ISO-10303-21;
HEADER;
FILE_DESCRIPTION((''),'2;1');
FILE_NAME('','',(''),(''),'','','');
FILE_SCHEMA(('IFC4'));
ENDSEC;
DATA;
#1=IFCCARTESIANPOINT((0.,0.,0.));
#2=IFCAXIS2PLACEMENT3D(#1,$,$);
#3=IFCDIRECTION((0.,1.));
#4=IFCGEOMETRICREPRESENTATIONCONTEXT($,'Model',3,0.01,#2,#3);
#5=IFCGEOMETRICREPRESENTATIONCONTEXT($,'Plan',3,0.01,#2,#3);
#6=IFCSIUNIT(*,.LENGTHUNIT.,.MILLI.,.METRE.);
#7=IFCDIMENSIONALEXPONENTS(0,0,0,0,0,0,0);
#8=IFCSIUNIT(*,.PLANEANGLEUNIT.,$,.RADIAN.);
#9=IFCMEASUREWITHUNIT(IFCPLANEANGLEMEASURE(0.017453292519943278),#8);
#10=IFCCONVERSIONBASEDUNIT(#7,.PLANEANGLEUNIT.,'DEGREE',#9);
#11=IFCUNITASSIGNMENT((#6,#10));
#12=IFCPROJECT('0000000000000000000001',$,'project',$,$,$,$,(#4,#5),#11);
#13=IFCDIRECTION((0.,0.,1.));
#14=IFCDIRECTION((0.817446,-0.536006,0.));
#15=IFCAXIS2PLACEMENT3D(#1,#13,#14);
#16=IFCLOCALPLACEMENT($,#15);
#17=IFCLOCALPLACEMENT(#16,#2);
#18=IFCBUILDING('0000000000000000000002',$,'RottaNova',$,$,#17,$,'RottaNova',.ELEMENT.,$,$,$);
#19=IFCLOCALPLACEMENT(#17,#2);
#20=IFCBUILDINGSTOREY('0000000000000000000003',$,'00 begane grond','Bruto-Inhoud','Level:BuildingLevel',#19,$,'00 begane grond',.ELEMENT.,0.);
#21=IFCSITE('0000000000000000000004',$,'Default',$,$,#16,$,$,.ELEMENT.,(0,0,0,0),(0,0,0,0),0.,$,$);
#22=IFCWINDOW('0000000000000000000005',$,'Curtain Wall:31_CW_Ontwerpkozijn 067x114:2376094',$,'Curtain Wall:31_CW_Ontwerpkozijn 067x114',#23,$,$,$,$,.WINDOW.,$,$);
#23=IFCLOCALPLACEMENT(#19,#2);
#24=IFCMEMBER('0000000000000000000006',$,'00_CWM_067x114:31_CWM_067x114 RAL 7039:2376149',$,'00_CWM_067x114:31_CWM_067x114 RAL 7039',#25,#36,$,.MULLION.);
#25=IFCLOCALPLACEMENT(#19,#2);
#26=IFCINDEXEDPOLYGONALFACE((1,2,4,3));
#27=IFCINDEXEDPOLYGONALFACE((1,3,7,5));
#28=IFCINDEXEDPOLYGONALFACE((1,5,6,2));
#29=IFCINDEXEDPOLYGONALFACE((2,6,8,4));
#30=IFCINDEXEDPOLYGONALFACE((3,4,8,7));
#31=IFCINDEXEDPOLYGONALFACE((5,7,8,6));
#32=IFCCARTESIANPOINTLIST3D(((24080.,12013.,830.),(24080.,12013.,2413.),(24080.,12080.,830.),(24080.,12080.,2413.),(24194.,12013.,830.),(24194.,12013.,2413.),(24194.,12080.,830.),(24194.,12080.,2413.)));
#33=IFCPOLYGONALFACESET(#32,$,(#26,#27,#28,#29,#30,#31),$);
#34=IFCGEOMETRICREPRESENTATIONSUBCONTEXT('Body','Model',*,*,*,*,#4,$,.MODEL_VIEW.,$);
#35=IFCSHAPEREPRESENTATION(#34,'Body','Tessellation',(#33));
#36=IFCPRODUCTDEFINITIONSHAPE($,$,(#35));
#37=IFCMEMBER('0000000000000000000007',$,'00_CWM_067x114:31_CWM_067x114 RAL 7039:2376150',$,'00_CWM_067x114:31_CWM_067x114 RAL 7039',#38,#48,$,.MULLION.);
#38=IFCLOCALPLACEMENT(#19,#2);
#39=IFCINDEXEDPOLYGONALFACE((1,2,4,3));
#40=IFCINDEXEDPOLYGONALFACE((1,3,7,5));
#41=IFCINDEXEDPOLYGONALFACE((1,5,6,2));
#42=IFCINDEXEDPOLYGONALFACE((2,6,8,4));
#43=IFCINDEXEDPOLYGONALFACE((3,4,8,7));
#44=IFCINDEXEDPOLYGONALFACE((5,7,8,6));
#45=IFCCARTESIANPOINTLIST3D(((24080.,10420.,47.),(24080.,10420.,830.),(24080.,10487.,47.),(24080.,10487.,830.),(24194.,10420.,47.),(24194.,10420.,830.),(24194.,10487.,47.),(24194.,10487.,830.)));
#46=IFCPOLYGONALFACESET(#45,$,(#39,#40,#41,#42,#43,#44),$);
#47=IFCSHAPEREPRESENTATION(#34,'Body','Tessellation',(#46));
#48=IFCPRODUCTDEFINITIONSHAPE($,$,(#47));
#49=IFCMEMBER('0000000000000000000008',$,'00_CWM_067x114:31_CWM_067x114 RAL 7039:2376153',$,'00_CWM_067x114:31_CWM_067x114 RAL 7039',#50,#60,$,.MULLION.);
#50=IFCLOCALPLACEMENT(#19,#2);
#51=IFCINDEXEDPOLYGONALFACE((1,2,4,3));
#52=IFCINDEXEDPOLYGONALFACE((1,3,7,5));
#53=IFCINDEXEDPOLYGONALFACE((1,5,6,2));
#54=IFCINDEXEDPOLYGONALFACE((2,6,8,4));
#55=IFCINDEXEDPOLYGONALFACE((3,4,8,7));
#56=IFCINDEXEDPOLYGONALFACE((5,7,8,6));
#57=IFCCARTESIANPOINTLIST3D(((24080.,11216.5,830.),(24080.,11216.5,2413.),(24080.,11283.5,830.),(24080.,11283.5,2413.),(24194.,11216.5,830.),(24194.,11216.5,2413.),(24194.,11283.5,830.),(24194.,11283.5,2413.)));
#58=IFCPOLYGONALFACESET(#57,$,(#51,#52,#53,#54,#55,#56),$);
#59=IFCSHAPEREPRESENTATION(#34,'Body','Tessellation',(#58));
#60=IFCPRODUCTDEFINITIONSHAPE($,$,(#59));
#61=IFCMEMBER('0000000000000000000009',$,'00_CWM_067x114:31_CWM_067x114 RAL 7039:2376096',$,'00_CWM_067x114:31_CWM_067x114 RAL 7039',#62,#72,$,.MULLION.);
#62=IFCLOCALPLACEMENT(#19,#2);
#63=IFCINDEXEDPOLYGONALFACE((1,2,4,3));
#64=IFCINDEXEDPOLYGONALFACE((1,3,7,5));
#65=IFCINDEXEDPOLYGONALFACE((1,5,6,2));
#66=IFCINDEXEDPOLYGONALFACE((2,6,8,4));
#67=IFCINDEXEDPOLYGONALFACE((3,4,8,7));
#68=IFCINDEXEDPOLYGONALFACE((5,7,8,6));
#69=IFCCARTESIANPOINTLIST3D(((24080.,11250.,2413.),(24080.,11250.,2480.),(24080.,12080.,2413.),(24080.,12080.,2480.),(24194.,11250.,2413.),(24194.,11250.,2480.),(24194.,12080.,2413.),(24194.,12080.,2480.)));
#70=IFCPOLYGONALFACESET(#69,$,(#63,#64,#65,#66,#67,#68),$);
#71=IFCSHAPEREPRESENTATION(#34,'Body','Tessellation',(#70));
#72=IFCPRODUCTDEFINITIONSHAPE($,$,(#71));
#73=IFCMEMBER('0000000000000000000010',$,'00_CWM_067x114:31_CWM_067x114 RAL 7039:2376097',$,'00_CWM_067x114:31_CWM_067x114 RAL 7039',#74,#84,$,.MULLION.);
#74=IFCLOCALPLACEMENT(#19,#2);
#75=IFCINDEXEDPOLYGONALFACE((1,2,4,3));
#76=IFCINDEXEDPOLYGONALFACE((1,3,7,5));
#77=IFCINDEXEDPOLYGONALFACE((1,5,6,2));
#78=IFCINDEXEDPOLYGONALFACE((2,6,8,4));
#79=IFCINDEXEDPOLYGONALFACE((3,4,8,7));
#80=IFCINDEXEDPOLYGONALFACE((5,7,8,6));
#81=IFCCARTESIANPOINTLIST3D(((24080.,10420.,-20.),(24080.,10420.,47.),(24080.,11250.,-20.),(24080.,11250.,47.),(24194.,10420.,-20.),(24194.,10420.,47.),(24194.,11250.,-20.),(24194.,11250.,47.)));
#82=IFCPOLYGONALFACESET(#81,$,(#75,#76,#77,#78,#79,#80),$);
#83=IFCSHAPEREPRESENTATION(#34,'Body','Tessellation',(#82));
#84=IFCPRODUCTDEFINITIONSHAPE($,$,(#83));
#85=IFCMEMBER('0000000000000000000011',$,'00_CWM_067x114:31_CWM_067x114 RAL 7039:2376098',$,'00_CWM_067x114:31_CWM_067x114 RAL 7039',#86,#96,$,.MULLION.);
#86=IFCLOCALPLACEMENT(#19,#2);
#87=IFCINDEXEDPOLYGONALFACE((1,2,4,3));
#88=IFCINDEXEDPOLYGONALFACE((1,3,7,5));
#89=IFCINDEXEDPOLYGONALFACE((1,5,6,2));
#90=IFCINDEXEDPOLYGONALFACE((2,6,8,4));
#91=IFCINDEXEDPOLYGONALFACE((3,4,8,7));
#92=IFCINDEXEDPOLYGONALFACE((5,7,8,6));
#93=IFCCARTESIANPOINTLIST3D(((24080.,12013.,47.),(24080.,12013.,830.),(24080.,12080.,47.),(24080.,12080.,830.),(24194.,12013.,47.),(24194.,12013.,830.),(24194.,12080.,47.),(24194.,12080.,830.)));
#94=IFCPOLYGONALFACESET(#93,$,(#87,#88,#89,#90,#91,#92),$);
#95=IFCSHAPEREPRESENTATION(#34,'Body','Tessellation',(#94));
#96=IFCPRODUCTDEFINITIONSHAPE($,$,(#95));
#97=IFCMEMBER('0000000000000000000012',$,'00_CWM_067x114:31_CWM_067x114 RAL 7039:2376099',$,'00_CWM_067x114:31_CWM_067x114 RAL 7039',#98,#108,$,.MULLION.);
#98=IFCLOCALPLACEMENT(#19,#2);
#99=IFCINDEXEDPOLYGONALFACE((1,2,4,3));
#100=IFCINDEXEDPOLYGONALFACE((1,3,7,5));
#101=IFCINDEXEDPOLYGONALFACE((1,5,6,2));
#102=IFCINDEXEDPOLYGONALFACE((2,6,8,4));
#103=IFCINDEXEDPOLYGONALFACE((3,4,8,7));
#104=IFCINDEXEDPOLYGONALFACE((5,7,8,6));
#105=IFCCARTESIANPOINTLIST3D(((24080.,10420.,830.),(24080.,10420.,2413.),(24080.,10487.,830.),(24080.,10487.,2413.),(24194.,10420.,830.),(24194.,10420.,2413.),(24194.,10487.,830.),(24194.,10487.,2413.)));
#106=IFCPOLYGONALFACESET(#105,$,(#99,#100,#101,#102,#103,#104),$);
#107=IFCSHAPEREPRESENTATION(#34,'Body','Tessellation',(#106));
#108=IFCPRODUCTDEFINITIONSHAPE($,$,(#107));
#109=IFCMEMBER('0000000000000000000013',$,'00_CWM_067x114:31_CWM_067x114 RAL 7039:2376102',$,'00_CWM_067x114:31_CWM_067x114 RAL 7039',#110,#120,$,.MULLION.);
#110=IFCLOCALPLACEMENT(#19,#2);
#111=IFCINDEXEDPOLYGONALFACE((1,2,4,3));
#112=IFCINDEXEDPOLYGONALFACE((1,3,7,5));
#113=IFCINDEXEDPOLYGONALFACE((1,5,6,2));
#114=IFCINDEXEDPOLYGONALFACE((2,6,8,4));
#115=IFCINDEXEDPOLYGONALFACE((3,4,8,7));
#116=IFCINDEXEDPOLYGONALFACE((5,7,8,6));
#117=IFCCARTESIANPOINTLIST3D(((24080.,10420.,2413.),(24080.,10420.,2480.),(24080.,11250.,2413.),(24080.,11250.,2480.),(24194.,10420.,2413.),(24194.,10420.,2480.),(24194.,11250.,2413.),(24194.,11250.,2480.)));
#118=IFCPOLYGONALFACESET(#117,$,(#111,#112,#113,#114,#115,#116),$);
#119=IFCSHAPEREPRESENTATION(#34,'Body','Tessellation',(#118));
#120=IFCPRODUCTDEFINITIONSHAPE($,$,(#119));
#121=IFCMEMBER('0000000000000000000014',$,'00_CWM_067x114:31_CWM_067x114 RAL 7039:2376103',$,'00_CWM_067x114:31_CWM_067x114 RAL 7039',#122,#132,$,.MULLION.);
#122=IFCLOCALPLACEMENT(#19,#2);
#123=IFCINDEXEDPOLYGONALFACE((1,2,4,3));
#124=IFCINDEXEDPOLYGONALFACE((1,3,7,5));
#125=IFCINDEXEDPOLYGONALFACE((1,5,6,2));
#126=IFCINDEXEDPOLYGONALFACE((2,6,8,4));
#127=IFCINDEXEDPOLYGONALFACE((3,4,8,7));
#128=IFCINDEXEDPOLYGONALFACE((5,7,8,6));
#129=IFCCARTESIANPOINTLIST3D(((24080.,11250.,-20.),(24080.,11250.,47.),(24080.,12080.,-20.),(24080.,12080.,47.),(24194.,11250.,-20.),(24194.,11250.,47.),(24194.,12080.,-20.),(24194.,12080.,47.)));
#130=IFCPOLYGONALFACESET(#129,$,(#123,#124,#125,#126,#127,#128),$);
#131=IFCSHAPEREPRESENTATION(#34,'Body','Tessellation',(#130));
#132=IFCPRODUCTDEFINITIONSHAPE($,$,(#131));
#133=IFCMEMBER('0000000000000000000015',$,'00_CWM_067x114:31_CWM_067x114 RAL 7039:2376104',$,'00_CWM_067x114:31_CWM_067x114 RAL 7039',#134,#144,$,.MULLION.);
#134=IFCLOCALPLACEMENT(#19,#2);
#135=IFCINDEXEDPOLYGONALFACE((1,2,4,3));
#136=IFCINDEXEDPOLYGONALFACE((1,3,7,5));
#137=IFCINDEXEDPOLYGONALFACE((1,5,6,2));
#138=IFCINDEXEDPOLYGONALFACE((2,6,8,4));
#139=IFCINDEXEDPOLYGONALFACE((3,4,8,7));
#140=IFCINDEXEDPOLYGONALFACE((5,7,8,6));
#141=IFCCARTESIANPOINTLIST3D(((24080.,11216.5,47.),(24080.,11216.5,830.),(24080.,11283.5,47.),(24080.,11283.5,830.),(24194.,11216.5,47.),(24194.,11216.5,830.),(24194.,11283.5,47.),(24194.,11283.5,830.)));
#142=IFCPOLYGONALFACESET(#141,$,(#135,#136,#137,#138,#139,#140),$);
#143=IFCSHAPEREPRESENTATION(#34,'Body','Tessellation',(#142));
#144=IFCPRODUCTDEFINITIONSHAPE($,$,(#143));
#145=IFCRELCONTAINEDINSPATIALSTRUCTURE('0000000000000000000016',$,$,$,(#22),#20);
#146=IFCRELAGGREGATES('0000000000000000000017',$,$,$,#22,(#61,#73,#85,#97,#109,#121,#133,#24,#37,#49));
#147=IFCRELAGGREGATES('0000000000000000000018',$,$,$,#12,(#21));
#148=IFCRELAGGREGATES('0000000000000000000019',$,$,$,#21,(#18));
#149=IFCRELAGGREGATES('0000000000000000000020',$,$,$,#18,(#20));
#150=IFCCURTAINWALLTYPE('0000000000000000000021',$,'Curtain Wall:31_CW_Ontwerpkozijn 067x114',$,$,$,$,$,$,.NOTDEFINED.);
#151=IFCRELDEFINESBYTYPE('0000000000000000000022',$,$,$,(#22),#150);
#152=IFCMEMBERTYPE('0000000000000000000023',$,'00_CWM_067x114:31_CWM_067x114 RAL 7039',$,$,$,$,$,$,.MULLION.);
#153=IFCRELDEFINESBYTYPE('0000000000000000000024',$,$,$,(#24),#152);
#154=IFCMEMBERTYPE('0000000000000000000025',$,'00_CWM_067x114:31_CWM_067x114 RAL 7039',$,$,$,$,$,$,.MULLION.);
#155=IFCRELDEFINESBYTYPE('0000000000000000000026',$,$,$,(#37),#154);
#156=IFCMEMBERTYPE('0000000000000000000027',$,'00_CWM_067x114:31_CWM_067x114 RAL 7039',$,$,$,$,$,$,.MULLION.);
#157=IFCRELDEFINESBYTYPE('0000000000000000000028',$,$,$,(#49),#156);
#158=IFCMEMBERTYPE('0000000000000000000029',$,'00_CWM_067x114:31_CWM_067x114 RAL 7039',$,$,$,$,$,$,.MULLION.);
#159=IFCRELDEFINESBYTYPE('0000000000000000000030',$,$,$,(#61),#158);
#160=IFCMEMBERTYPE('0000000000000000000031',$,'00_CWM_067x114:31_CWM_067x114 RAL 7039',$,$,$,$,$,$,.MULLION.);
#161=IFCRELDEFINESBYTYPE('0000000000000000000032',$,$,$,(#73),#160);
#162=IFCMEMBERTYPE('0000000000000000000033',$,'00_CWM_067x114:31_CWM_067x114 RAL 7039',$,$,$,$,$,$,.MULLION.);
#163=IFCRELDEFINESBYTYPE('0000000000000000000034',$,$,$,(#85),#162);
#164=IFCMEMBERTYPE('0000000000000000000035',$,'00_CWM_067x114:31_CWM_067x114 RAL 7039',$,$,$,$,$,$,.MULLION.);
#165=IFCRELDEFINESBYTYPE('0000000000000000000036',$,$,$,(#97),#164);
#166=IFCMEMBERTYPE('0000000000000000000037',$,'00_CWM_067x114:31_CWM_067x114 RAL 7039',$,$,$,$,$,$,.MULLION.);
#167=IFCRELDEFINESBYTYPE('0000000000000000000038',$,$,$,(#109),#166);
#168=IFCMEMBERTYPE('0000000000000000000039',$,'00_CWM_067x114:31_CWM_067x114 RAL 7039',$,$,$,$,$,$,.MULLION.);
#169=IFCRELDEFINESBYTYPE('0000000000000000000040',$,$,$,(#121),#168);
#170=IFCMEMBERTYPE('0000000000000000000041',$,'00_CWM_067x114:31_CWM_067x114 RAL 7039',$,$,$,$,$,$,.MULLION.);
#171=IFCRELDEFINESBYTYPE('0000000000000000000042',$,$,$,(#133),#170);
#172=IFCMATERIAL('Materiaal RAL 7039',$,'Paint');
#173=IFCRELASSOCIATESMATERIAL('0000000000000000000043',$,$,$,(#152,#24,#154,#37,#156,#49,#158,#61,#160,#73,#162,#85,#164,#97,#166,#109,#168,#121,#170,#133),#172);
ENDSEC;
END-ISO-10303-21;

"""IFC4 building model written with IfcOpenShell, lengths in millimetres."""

from ifc_helpers import new_model, entity, si_unit, converted_unit, direction, frame, origin, place, context, subcontext, project, spatial, indexed_curve, outline, extrude, source, transform, mapped, material, type_object, type_shapes, element, aggregate, save


model = new_model("IFC4")

# Units and contexts
model_context = context("Model", 3, precision=0.01, world=origin(), true_north=direction((0.0, 1.0)))
plan_context = context("Plan", 3, precision=0.01, world=origin(), true_north=direction((0.0, 1.0)))
body_context = subcontext(model_context, "Body", "Model", "MODEL_VIEW")
ifc_project = project(units=[si_unit("LENGTHUNIT", "METRE", prefix="MILLI"), converted_unit("PLANEANGLEUNIT", "DEGREE", entity("IfcPlaneAngleMeasure", 0.017453292519943278), si_unit("PLANEANGLEUNIT", "RADIAN"), dimensions=[0, 0, 0, 0, 0, 0, 0])], contexts=[model_context, plan_context])

# Site, building, storey
site_placement = place(None, frame((0.0, 0.0, 0.0), z_axis=(0.0, 0.0, 1.0), x_axis=(0.817446, -0.536006, 0.0)))
site = spatial("IfcSite", under=ifc_project, at=site_placement, Name="Default", CompositionType="ELEMENT", RefLatitude=(0, 0, 0, 0), RefLongitude=(0, 0, 0, 0), RefElevation=0.0)
building_placement = place(site_placement, origin())
building = spatial("IfcBuilding", under=site, at=building_placement, Name="RottaNova", LongName="RottaNova", CompositionType="ELEMENT")
storey_placement = place(building_placement, origin())
storey = spatial("IfcBuildingStorey", under=building, at=storey_placement, Name="00 begane grond", Description="Bruto-Inhoud", ObjectType="Level:BuildingLevel", LongName="00 begane grond", CompositionType="ELEMENT", Elevation=0.0)

# Window, members
curtain_wall_type = type_object("IfcCurtainWallType", Name="Curtain Wall:31_CW_Ontwerpkozijn 067x114", PredefinedType="NOTDEFINED")
window_placement = place(storey_placement, origin())
window = element("IfcWindow", 1, at=window_placement, inside=storey, type_object=curtain_wall_type, Name="Curtain Wall:31_CW_Ontwerpkozijn 067x114:2376094", ObjectType="Curtain Wall:31_CW_Ontwerpkozijn 067x114", PredefinedType="WINDOW")
ifc_material_1 = material(Name="Materiaal RAL 7039", Category="Paint")
member_type_1 = type_object("IfcMemberType", Name="00_CWM_067x114:31_CWM_067x114 RAL 7039", PredefinedType="MULLION", material=ifc_material_1)
shared_shape_1 = source(origin(), body_context, "Body", "SweptSolid", [
    extrude(outline(indexed_curve([(-33.5, -57.0), (33.5, -57.0), (33.5, 57.0), (-33.5, 57.0), (-33.5, -57.0)], self_intersect=False)), frame((-33.5, 57.0, -1583.0), z_axis=(0.0, 0.0, 1.0), x_axis=(-1.0, 0.0, 0.0)), (0.0, 0.0, 1.0), 1583.0),
])
type_shapes(member_type_1, [shared_shape_1])
member_1_placement = place(window_placement, frame((24080.0, 12080.0, 830.0), z_axis=(0.0, 0.0, -1.0), x_axis=(0.0, 1.0, 0.0)))
member_1 = element("IfcMember", 2, at=member_1_placement, type_object=member_type_1, material=ifc_material_1, Name="00_CWM_067x114:31_CWM_067x114 RAL 7039:2376149", ObjectType="00_CWM_067x114:31_CWM_067x114 RAL 7039", PredefinedType="MULLION", context=body_context, shape_type="MappedRepresentation", body=[
    mapped(shared_shape_1, transform((0.0, 0.0, 0.0), scale=1.0)),
])
member_type_2 = type_object("IfcMemberType", Name="00_CWM_067x114:31_CWM_067x114 RAL 7039", PredefinedType="MULLION", material=ifc_material_1)
shared_shape_2 = source(origin(), body_context, "Body", "SweptSolid", [
    extrude(outline(indexed_curve([(-33.5, -57.0), (33.5, -57.0), (33.5, 57.0), (-33.5, 57.0), (-33.5, -57.0)], self_intersect=False)), frame((-33.5, 57.0, -783.0), z_axis=(0.0, 0.0, 1.0), x_axis=(-1.0, 0.0, 0.0)), (0.0, 0.0, 1.0), 783.0),
])
type_shapes(member_type_2, [shared_shape_2])
member_2_placement = place(window_placement, frame((24080.0, 10420.0, 830.0), z_axis=(0.0, 0.0, 1.0), x_axis=(0.0, -1.0, 0.0)))
member_2 = element("IfcMember", 3, at=member_2_placement, type_object=member_type_2, material=ifc_material_1, Name="00_CWM_067x114:31_CWM_067x114 RAL 7039:2376150", ObjectType="00_CWM_067x114:31_CWM_067x114 RAL 7039", PredefinedType="MULLION", context=body_context, shape_type="MappedRepresentation", body=[
    mapped(shared_shape_2, transform((0.0, 0.0, 0.0), scale=1.0)),
])
member_type_3 = type_object("IfcMemberType", Name="00_CWM_067x114:31_CWM_067x114 RAL 7039", PredefinedType="MULLION", material=ifc_material_1)
shared_shape_3 = source(origin(), body_context, "Body", "SweptSolid", [
    extrude(outline(indexed_curve([(-33.5, -57.0), (33.5, -57.0), (33.5, 57.0), (-33.5, 57.0), (-33.5, -57.0)], self_intersect=False)), frame((0.0, 57.0, -1583.0), z_axis=(0.0, 0.0, 1.0), x_axis=(-1.0, 0.0, 0.0)), (0.0, 0.0, 1.0), 1583.0),
])
type_shapes(member_type_3, [shared_shape_3])
member_3_placement = place(window_placement, frame((24080.0, 11250.0, 830.0), z_axis=(0.0, 0.0, -1.0), x_axis=(0.0, 1.0, 0.0)))
member_3 = element("IfcMember", 4, at=member_3_placement, type_object=member_type_3, material=ifc_material_1, Name="00_CWM_067x114:31_CWM_067x114 RAL 7039:2376153", ObjectType="00_CWM_067x114:31_CWM_067x114 RAL 7039", PredefinedType="MULLION", context=body_context, shape_type="MappedRepresentation", body=[
    mapped(shared_shape_3, transform((0.0, 0.0, 0.0), scale=1.0)),
])
member_type_4 = type_object("IfcMemberType", Name="00_CWM_067x114:31_CWM_067x114 RAL 7039", PredefinedType="MULLION", material=ifc_material_1)
shared_shape_4 = source(origin(), body_context, "Body", "SweptSolid", [
    extrude(outline(indexed_curve([(-33.5, -57.0), (33.5, -57.0), (33.5, 57.0), (-33.5, 57.0), (-33.5, -57.0)], self_intersect=False)), frame((-33.5, 57.0, -830.0), z_axis=(0.0, 0.0, 1.0), x_axis=(-1.0, 0.0, 0.0)), (0.0, 0.0, 1.0), 830.0),
])
type_shapes(member_type_4, [shared_shape_4])
member_4_placement = place(window_placement, frame((24080.0, 12080.0, 2480.0), z_axis=(0.0, 1.0, 0.0), x_axis=(0.0, 0.0, 1.0)))
member_4 = element("IfcMember", 5, at=member_4_placement, type_object=member_type_4, material=ifc_material_1, Name="00_CWM_067x114:31_CWM_067x114 RAL 7039:2376096", ObjectType="00_CWM_067x114:31_CWM_067x114 RAL 7039", PredefinedType="MULLION", context=body_context, shape_type="MappedRepresentation", body=[
    mapped(shared_shape_4, transform((0.0, 0.0, 0.0), scale=1.0)),
])
member_type_5 = type_object("IfcMemberType", Name="00_CWM_067x114:31_CWM_067x114 RAL 7039", PredefinedType="MULLION", material=ifc_material_1)
shared_shape_5 = source(origin(), body_context, "Body", "SweptSolid", [
    extrude(outline(indexed_curve([(-33.5, -57.0), (33.5, -57.0), (33.5, 57.0), (-33.5, 57.0), (-33.5, -57.0)], self_intersect=False)), frame((-33.5, 57.0, -830.0), z_axis=(0.0, 0.0, 1.0), x_axis=(-1.0, 0.0, 0.0)), (0.0, 0.0, 1.0), 830.0),
])
type_shapes(member_type_5, [shared_shape_5])
member_5_placement = place(window_placement, frame((24080.0, 10420.0, -20.0), z_axis=(0.0, -1.0, 0.0), x_axis=(0.0, 0.0, -1.0)))
member_5 = element("IfcMember", 6, at=member_5_placement, type_object=member_type_5, material=ifc_material_1, Name="00_CWM_067x114:31_CWM_067x114 RAL 7039:2376097", ObjectType="00_CWM_067x114:31_CWM_067x114 RAL 7039", PredefinedType="MULLION", context=body_context, shape_type="MappedRepresentation", body=[
    mapped(shared_shape_5, transform((0.0, 0.0, 0.0), scale=1.0)),
])
member_type_6 = type_object("IfcMemberType", Name="00_CWM_067x114:31_CWM_067x114 RAL 7039", PredefinedType="MULLION", material=ifc_material_1)
shared_shape_6 = source(origin(), body_context, "Body", "SweptSolid", [
    extrude(outline(indexed_curve([(-33.5, -57.0), (33.5, -57.0), (33.5, 57.0), (-33.5, 57.0), (-33.5, -57.0)], self_intersect=False)), frame((-33.5, 57.0, -783.0), z_axis=(0.0, 0.0, 1.0), x_axis=(-1.0, 0.0, 0.0)), (0.0, 0.0, 1.0), 783.0),
])
type_shapes(member_type_6, [shared_shape_6])
member_6_placement = place(window_placement, frame((24080.0, 12080.0, 47.0), z_axis=(0.0, 0.0, -1.0), x_axis=(0.0, 1.0, 0.0)))
member_6 = element("IfcMember", 7, at=member_6_placement, type_object=member_type_6, material=ifc_material_1, Name="00_CWM_067x114:31_CWM_067x114 RAL 7039:2376098", ObjectType="00_CWM_067x114:31_CWM_067x114 RAL 7039", PredefinedType="MULLION", context=body_context, shape_type="MappedRepresentation", body=[
    mapped(shared_shape_6, transform((0.0, 0.0, 0.0), scale=1.0)),
])
member_type_7 = type_object("IfcMemberType", Name="00_CWM_067x114:31_CWM_067x114 RAL 7039", PredefinedType="MULLION", material=ifc_material_1)
shared_shape_7 = source(origin(), body_context, "Body", "SweptSolid", [
    extrude(outline(indexed_curve([(-33.5, -57.0), (33.5, -57.0), (33.5, 57.0), (-33.5, 57.0), (-33.5, -57.0)], self_intersect=False)), frame((-33.5, 57.0, -1583.0), z_axis=(0.0, 0.0, 1.0), x_axis=(-1.0, 0.0, 0.0)), (0.0, 0.0, 1.0), 1583.0),
])
type_shapes(member_type_7, [shared_shape_7])
member_7_placement = place(window_placement, frame((24080.0, 10420.0, 2413.0), z_axis=(0.0, 0.0, 1.0), x_axis=(0.0, -1.0, 0.0)))
member_7 = element("IfcMember", 8, at=member_7_placement, type_object=member_type_7, material=ifc_material_1, Name="00_CWM_067x114:31_CWM_067x114 RAL 7039:2376099", ObjectType="00_CWM_067x114:31_CWM_067x114 RAL 7039", PredefinedType="MULLION", context=body_context, shape_type="MappedRepresentation", body=[
    mapped(shared_shape_7, transform((0.0, 0.0, 0.0), scale=1.0)),
])
member_type_8 = type_object("IfcMemberType", Name="00_CWM_067x114:31_CWM_067x114 RAL 7039", PredefinedType="MULLION", material=ifc_material_1)
shared_shape_8 = source(origin(), body_context, "Body", "SweptSolid", [
    extrude(outline(indexed_curve([(-33.5, -57.0), (33.5, -57.0), (33.5, 57.0), (-33.5, 57.0), (-33.5, -57.0)], self_intersect=False)), frame((-33.5, 57.0, -830.0), z_axis=(0.0, 0.0, 1.0), x_axis=(-1.0, 0.0, 0.0)), (0.0, 0.0, 1.0), 830.0),
])
type_shapes(member_type_8, [shared_shape_8])
member_8_placement = place(window_placement, frame((24080.0, 11250.0, 2480.0), z_axis=(0.0, 1.0, 0.0), x_axis=(0.0, 0.0, 1.0)))
member_8 = element("IfcMember", 9, at=member_8_placement, type_object=member_type_8, material=ifc_material_1, Name="00_CWM_067x114:31_CWM_067x114 RAL 7039:2376102", ObjectType="00_CWM_067x114:31_CWM_067x114 RAL 7039", PredefinedType="MULLION", context=body_context, shape_type="MappedRepresentation", body=[
    mapped(shared_shape_8, transform((0.0, 0.0, 0.0), scale=1.0)),
])
member_type_9 = type_object("IfcMemberType", Name="00_CWM_067x114:31_CWM_067x114 RAL 7039", PredefinedType="MULLION", material=ifc_material_1)
shared_shape_9 = source(origin(), body_context, "Body", "SweptSolid", [
    extrude(outline(indexed_curve([(-33.5, -57.0), (33.5, -57.0), (33.5, 57.0), (-33.5, 57.0), (-33.5, -57.0)], self_intersect=False)), frame((-33.5, 57.0, -830.0), z_axis=(0.0, 0.0, 1.0), x_axis=(-1.0, 0.0, 0.0)), (0.0, 0.0, 1.0), 830.0),
])
type_shapes(member_type_9, [shared_shape_9])
member_9_placement = place(window_placement, frame((24080.0, 11250.0, -20.0), z_axis=(0.0, -1.0, 0.0), x_axis=(0.0, 0.0, -1.0)))
member_9 = element("IfcMember", 10, at=member_9_placement, type_object=member_type_9, material=ifc_material_1, Name="00_CWM_067x114:31_CWM_067x114 RAL 7039:2376103", ObjectType="00_CWM_067x114:31_CWM_067x114 RAL 7039", PredefinedType="MULLION", context=body_context, shape_type="MappedRepresentation", body=[
    mapped(shared_shape_9, transform((0.0, 0.0, 0.0), scale=1.0)),
])
member_type_10 = type_object("IfcMemberType", Name="00_CWM_067x114:31_CWM_067x114 RAL 7039", PredefinedType="MULLION", material=ifc_material_1)
shared_shape_10 = source(origin(), body_context, "Body", "SweptSolid", [
    extrude(outline(indexed_curve([(-33.5, -57.0), (33.5, -57.0), (33.5, 57.0), (-33.5, 57.0), (-33.5, -57.0)], self_intersect=False)), frame((0.0, 57.0, -783.0), z_axis=(0.0, 0.0, 1.0), x_axis=(-1.0, 0.0, 0.0)), (0.0, 0.0, 1.0), 783.0),
])
type_shapes(member_type_10, [shared_shape_10])
member_10_placement = place(window_placement, frame((24080.0, 11250.0, 47.0), z_axis=(0.0, 0.0, -1.0), x_axis=(0.0, 1.0, 0.0)))
member_10 = element("IfcMember", 11, at=member_10_placement, type_object=member_type_10, material=ifc_material_1, Name="00_CWM_067x114:31_CWM_067x114 RAL 7039:2376104", ObjectType="00_CWM_067x114:31_CWM_067x114 RAL 7039", PredefinedType="MULLION", context=body_context, shape_type="MappedRepresentation", body=[
    mapped(shared_shape_10, transform((0.0, 0.0, 0.0), scale=1.0)),
])
aggregate(window, [member_4, member_5, member_6, member_7, member_8, member_9, member_10, member_1, member_2, member_3])

save(model, "model.ifc")
